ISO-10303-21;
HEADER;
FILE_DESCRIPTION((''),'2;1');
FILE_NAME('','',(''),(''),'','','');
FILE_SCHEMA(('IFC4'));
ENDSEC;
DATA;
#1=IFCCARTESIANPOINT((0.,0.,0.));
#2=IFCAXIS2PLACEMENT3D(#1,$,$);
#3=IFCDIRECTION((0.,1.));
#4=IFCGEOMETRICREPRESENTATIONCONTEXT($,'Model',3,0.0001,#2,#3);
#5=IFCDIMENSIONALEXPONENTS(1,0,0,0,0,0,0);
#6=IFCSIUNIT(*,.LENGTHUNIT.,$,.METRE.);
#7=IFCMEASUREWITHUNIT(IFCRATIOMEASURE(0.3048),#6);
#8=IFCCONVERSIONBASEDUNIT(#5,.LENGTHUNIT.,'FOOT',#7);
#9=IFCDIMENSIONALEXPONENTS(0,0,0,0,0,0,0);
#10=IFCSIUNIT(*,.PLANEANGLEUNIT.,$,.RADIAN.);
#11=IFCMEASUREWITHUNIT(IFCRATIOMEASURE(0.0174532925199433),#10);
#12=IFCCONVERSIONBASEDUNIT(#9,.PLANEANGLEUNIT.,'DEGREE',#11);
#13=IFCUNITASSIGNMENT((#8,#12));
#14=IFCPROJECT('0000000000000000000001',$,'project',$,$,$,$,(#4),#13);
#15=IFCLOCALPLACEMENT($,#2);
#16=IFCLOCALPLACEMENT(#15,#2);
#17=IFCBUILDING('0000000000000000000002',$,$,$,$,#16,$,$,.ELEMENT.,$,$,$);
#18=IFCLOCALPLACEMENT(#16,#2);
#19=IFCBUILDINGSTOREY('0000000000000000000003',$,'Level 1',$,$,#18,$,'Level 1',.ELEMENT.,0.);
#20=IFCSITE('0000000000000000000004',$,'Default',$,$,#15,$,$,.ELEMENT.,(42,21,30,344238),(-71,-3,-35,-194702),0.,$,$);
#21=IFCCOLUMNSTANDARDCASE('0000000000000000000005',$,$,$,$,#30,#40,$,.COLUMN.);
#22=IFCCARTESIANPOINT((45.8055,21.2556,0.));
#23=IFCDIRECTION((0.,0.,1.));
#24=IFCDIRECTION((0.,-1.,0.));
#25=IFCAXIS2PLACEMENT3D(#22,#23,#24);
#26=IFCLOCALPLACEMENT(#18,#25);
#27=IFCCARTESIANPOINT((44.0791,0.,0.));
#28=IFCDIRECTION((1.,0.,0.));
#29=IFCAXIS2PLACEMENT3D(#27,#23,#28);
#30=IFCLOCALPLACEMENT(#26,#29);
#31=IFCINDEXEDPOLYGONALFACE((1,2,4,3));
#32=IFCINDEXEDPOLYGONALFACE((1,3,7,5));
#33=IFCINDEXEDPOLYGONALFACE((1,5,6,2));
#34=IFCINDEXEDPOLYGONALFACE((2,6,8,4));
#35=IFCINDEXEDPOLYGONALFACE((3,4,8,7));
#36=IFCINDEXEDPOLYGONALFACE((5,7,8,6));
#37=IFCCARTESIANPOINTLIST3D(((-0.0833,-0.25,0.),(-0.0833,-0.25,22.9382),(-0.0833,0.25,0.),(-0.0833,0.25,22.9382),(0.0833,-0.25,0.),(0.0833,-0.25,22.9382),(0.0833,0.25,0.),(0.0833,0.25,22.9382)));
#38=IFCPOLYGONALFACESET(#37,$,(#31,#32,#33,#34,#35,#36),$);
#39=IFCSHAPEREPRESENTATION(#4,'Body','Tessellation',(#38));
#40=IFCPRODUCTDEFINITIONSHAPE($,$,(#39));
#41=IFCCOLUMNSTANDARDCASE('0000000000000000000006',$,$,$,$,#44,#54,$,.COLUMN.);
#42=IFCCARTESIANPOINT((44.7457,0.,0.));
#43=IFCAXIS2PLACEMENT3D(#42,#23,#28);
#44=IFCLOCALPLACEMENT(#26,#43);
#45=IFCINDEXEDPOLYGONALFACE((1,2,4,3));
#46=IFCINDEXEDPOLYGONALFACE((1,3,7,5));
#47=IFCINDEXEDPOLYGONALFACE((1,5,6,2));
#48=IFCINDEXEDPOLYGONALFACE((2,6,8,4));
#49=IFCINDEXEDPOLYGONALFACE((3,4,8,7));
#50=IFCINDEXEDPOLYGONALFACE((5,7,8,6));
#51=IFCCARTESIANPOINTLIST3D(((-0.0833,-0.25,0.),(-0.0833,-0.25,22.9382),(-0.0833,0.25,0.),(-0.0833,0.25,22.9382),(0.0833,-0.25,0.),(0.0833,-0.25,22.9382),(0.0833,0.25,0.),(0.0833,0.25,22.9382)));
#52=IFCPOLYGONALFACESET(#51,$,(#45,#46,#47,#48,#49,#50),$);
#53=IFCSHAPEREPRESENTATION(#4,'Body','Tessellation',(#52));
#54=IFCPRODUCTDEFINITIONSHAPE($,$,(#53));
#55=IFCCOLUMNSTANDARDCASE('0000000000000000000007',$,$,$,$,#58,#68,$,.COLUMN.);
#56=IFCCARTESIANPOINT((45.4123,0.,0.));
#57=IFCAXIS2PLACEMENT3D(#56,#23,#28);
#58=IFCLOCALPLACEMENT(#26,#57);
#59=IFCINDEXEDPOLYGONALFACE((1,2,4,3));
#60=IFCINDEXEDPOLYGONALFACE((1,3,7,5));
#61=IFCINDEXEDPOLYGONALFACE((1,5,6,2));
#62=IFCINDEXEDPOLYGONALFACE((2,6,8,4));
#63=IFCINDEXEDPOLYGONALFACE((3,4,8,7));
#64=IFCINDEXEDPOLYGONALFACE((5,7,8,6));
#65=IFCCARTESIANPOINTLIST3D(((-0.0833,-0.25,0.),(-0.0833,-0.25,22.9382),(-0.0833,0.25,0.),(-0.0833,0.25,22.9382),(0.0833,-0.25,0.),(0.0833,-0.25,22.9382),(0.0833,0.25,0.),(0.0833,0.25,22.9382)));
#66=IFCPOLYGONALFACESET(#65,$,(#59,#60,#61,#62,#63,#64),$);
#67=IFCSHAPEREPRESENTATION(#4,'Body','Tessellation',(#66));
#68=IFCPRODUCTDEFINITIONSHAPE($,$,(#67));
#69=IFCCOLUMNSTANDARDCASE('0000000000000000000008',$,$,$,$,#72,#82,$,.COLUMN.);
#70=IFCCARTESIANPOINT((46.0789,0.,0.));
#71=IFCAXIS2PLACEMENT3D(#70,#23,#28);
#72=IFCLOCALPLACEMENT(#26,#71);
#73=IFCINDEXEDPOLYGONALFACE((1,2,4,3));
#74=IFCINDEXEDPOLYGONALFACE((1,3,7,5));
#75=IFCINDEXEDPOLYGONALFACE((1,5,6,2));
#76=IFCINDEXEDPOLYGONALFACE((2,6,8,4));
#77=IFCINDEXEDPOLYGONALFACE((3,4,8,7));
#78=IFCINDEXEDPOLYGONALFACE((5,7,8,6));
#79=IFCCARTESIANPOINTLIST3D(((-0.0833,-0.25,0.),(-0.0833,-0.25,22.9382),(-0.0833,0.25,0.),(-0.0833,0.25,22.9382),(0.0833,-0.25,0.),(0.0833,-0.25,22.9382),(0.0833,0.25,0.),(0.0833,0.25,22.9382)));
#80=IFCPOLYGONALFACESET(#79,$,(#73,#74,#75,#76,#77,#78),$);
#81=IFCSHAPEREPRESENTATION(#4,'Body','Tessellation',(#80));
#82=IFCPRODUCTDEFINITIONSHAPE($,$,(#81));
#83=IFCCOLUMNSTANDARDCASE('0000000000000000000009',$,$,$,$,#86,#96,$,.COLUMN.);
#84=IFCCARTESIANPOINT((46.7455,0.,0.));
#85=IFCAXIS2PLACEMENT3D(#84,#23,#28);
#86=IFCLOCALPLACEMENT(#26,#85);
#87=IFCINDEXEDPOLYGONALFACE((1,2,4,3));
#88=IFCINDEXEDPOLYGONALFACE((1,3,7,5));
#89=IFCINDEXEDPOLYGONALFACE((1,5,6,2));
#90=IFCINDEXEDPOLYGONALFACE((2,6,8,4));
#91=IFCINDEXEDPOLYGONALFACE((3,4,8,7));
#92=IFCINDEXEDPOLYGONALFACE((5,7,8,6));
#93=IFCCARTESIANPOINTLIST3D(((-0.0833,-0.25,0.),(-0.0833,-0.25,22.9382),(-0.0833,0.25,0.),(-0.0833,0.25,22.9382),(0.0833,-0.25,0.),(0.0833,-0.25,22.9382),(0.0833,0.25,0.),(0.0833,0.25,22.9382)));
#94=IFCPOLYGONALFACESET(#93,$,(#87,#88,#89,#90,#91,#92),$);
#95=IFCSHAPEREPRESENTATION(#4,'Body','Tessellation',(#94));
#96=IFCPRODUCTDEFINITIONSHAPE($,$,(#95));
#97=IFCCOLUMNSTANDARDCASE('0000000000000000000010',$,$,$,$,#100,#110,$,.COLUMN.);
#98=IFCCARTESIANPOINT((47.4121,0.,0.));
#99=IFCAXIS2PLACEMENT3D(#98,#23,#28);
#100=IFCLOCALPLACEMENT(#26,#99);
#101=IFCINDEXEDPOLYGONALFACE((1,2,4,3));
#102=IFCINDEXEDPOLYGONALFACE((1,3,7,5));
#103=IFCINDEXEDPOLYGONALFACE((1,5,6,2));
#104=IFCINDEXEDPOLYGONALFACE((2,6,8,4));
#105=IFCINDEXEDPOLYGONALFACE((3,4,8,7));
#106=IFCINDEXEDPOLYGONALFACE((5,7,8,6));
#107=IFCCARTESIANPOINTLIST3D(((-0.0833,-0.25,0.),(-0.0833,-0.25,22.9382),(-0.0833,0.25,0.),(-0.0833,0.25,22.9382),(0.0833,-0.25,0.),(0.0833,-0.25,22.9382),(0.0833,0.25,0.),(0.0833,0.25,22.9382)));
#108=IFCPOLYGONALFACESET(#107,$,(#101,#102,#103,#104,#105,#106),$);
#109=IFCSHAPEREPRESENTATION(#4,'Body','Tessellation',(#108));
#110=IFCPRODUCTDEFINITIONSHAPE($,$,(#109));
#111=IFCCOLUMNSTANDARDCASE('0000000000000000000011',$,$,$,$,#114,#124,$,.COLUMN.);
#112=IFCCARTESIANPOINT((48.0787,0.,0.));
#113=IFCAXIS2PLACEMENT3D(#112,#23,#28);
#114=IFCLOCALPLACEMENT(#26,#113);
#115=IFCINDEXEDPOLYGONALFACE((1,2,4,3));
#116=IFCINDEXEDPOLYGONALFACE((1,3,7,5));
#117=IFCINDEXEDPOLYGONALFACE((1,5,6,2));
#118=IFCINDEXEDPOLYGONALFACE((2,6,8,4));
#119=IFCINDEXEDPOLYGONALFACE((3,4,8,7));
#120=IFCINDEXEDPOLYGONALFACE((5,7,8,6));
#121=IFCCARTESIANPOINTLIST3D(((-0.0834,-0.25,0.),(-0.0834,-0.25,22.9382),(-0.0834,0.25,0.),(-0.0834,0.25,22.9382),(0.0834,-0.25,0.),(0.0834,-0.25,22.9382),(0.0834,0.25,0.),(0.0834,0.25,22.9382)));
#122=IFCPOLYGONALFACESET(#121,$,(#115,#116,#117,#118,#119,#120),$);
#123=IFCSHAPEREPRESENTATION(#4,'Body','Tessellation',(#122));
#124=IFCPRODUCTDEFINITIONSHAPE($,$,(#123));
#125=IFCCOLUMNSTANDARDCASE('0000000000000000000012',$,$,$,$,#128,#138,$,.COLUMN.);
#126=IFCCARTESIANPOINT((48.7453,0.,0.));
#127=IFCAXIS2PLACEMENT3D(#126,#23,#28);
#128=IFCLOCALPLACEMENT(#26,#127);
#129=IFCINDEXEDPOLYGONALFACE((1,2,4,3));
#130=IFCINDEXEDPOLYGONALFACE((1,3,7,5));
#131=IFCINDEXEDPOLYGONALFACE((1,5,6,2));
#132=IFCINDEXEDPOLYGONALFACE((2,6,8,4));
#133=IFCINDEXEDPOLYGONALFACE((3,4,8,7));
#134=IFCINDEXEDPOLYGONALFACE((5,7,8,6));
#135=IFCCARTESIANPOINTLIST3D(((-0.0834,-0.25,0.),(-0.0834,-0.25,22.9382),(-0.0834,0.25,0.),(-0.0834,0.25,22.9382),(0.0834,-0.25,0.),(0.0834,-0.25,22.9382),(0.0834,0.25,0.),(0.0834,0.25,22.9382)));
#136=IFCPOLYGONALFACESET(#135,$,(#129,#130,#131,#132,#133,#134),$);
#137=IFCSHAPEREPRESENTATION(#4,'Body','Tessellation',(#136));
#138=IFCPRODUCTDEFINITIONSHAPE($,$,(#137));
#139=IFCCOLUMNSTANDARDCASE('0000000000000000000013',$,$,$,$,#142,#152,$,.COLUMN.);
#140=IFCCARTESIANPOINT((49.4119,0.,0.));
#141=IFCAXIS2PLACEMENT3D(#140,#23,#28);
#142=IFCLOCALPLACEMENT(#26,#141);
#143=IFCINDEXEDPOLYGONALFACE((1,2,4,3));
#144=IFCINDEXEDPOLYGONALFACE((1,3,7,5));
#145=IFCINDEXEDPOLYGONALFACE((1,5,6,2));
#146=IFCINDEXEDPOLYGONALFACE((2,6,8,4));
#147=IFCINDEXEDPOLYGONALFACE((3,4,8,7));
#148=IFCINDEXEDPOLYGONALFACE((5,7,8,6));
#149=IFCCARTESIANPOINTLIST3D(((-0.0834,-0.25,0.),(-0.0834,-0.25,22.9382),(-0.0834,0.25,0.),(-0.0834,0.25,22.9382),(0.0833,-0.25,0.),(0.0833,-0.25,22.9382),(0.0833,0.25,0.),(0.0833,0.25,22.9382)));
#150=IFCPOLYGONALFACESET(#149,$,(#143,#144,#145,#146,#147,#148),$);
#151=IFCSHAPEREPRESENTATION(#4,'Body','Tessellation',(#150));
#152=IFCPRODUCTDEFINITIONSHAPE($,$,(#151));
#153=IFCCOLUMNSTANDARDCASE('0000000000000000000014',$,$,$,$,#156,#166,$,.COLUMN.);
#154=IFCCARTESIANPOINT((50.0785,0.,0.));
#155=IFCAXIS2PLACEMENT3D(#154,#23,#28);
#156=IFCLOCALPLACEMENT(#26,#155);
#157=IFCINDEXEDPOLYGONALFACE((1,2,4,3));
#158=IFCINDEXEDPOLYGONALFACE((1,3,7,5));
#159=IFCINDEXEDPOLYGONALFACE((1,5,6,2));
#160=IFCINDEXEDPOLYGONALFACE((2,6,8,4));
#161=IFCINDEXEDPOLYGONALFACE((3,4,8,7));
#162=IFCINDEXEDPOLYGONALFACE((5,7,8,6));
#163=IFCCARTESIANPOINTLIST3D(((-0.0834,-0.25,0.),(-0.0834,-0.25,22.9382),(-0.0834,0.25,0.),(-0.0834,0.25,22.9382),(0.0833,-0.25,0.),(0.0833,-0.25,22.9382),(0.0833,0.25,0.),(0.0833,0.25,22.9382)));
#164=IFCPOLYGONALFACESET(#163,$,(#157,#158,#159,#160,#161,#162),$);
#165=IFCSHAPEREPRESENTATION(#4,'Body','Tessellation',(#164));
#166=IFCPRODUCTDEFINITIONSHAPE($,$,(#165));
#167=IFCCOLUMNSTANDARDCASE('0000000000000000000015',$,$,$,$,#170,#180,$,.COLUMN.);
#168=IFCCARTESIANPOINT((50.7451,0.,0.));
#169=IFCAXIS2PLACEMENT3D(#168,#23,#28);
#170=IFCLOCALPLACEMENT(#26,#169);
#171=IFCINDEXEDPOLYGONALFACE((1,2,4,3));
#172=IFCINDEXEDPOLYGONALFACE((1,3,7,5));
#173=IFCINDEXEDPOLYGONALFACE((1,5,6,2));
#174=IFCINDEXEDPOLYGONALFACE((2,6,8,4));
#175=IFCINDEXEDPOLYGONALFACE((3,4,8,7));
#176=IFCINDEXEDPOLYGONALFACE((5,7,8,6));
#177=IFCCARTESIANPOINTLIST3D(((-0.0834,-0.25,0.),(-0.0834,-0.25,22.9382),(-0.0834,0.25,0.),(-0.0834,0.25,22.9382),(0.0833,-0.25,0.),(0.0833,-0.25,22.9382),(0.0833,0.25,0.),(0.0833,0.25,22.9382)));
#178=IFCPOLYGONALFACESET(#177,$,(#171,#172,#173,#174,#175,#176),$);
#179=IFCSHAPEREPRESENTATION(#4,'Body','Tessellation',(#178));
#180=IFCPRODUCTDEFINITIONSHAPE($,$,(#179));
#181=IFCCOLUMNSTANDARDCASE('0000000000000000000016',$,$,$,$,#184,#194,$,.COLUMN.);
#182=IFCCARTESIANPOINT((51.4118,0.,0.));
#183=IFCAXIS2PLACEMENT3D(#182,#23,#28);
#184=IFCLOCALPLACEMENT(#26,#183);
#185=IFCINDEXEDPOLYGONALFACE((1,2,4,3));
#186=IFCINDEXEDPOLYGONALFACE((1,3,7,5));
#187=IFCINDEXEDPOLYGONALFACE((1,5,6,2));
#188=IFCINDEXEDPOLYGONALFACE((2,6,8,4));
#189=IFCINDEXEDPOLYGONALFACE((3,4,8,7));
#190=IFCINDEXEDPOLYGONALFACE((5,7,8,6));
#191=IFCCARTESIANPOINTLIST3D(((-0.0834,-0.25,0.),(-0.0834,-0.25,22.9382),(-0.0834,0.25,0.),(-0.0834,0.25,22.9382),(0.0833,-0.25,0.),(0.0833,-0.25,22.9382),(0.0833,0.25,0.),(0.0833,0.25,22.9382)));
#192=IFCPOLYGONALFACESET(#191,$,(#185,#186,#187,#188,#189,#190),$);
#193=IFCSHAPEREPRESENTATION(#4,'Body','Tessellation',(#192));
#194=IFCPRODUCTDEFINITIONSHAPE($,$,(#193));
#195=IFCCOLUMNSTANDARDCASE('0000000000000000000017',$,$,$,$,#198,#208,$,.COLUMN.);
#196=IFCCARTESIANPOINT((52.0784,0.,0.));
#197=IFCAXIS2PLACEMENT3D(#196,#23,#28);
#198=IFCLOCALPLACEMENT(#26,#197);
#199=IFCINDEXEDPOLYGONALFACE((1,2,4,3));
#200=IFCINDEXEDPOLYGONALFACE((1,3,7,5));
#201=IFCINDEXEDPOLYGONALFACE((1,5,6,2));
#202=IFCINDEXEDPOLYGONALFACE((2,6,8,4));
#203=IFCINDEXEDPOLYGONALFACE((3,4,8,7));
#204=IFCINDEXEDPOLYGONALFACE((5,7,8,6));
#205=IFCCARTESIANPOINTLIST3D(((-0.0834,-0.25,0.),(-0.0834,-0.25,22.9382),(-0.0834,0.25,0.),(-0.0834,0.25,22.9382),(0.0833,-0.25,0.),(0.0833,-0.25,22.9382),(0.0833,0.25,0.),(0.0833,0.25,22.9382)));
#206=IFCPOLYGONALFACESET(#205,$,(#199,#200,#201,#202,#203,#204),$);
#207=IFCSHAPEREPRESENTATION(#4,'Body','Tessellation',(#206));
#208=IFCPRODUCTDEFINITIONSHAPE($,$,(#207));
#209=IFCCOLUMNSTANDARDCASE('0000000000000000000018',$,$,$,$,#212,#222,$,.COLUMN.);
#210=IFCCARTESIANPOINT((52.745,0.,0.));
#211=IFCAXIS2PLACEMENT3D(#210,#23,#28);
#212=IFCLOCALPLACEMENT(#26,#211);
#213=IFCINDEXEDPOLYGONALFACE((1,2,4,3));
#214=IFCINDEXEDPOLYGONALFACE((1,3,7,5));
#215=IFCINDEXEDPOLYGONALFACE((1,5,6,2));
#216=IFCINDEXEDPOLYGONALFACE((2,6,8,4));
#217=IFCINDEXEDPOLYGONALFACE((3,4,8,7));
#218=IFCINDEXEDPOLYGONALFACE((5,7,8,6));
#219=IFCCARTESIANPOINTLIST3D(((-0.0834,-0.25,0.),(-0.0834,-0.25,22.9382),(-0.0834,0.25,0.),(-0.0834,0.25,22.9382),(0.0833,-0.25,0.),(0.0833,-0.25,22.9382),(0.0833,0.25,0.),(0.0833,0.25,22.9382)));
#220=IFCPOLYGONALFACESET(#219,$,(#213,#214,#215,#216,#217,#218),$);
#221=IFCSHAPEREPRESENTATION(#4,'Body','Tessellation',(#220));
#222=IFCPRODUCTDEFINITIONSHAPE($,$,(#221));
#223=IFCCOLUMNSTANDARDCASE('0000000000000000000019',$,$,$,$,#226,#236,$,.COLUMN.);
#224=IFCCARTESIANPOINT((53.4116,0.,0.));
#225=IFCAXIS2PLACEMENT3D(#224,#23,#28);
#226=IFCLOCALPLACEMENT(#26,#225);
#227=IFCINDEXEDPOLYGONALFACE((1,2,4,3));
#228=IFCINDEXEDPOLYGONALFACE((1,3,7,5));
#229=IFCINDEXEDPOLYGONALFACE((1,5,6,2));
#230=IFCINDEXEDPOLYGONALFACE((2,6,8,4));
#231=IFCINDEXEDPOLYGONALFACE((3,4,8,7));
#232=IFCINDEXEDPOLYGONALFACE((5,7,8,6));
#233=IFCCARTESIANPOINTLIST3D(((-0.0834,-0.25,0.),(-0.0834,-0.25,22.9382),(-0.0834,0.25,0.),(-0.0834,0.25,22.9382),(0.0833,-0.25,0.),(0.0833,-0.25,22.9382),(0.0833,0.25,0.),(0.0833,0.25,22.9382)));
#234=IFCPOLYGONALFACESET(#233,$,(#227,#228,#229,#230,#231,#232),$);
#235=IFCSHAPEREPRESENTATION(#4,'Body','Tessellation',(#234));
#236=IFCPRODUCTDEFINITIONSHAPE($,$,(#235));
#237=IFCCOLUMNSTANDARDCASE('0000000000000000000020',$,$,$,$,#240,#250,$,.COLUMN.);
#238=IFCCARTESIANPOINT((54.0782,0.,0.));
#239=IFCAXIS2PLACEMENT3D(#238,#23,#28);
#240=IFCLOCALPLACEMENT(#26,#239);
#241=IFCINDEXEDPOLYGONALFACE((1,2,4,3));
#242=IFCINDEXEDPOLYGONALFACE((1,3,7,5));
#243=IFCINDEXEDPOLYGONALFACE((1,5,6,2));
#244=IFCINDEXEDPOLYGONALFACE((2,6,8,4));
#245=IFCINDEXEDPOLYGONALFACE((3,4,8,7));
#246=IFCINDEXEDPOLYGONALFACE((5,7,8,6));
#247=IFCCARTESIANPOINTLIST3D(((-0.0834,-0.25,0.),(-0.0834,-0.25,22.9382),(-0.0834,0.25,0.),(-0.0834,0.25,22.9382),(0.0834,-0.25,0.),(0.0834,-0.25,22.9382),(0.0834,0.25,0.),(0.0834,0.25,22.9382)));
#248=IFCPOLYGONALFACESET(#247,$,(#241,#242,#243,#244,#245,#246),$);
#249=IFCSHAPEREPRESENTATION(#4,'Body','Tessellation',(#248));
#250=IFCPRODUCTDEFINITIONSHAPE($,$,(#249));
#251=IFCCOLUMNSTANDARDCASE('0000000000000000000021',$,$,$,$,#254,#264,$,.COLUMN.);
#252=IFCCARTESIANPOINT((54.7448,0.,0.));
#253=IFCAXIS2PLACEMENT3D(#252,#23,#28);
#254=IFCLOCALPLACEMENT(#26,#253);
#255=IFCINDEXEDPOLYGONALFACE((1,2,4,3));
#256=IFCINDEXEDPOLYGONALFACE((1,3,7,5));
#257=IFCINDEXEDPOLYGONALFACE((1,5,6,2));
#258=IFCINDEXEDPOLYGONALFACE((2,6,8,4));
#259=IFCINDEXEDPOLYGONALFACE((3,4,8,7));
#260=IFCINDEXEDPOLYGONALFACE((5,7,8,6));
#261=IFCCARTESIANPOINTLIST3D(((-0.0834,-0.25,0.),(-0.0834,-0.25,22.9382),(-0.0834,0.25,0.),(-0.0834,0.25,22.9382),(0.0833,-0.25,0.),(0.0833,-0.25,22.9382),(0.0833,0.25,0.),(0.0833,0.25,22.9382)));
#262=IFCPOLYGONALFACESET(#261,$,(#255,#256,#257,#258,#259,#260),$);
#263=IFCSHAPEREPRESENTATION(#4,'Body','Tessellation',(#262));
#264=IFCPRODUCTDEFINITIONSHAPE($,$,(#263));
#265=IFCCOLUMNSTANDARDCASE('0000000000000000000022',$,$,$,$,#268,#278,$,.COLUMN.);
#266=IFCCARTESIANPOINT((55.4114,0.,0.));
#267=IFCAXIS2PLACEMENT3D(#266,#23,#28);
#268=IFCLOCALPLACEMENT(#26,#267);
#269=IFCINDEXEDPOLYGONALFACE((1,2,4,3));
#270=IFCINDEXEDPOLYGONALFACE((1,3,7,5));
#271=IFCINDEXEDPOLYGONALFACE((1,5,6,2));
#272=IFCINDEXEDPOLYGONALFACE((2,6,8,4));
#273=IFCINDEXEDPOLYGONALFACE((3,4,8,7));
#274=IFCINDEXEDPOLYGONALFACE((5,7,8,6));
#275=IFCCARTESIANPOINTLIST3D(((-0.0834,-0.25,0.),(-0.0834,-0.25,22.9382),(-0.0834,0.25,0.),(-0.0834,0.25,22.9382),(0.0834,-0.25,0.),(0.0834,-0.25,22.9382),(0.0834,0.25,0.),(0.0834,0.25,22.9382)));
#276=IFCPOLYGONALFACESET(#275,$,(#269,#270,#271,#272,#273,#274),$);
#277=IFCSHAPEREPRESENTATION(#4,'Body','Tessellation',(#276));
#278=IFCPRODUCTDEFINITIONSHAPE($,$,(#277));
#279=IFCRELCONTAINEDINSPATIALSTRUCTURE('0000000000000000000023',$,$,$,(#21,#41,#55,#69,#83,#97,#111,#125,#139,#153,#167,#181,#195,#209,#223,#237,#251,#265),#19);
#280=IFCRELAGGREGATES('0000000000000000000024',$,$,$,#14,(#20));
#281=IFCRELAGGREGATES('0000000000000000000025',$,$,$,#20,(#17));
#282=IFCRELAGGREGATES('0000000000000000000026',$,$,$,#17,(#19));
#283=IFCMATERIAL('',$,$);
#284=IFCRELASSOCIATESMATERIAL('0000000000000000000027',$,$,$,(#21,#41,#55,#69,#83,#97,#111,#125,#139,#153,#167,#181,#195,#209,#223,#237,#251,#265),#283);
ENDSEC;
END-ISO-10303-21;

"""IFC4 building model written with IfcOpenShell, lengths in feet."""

from ifc_helpers import new_model, entity, si_unit, converted_unit, direction, frame, origin, place, context, project, spatial, rectangle, extrude, material, element, save


model = new_model("IFC4")

# Units and contexts
model_context = context("Model", 3, precision=0.0001, world=origin(), true_north=direction((0.0, 1.0)))
ifc_project = project(units=[converted_unit("LENGTHUNIT", "FOOT", entity("IfcRatioMeasure", 0.3048), si_unit("LENGTHUNIT", "METRE"), dimensions=[1, 0, 0, 0, 0, 0, 0]), converted_unit("PLANEANGLEUNIT", "DEGREE", entity("IfcRatioMeasure", 0.0174532925199433), si_unit("PLANEANGLEUNIT", "RADIAN"), dimensions=[0, 0, 0, 0, 0, 0, 0])], contexts=[model_context])

# Site, building, storey
site_placement = place(None, origin())
site = spatial("IfcSite", under=ifc_project, at=site_placement, Name="Default", CompositionType="ELEMENT", RefLatitude=(42, 21, 30, 344238), RefLongitude=(-71, -3, -35, -194702), RefElevation=0.0)
building_placement = place(site_placement, origin())
building = spatial("IfcBuilding", under=site, at=building_placement, CompositionType="ELEMENT")
storey_placement = place(building_placement, origin())
storey = spatial("IfcBuildingStorey", under=building, at=storey_placement, Name="Level 1", LongName="Level 1", CompositionType="ELEMENT", Elevation=0.0)

# Columns
ifc_material_1 = material(Name="")
placement = place(storey_placement, frame((45.8055, 21.2556, 0.0), z_axis=(0.0, 0.0, 1.0), x_axis=(0.0, -1.0, 0.0)))
for number, where, z_axis, x_axis in (
    (1, (44.0791, 0.0, 0.0), (0.0, 0.0, 1.0), (1.0, 0.0, 0.0)),
    (2, (44.7457, 0.0, 0.0), (0.0, 0.0, 1.0), (1.0, 0.0, 0.0)),
    (3, (45.4123, 0.0, 0.0), (0.0, 0.0, 1.0), (1.0, 0.0, 0.0)),
    (4, (46.0789, 0.0, 0.0), (0.0, 0.0, 1.0), (1.0, 0.0, 0.0)),
    (5, (46.7455, 0.0, 0.0), (0.0, 0.0, 1.0), (1.0, 0.0, 0.0)),
    (6, (47.4121, 0.0, 0.0), (0.0, 0.0, 1.0), (1.0, 0.0, 0.0)),
    (7, (48.0787, 0.0, 0.0), (0.0, 0.0, 1.0), (1.0, 0.0, 0.0)),
    (8, (48.7453, 0.0, 0.0), (0.0, 0.0, 1.0), (1.0, 0.0, 0.0)),
    (9, (49.4119, 0.0, 0.0), (0.0, 0.0, 1.0), (1.0, 0.0, 0.0)),
    (10, (50.0785, 0.0, 0.0), (0.0, 0.0, 1.0), (1.0, 0.0, 0.0)),
    (11, (50.7451, 0.0, 0.0), (0.0, 0.0, 1.0), (1.0, 0.0, 0.0)),
    (12, (51.4118, 0.0, 0.0), (0.0, 0.0, 1.0), (1.0, 0.0, 0.0)),
    (13, (52.0784, 0.0, 0.0), (0.0, 0.0, 1.0), (1.0, 0.0, 0.0)),
    (14, (52.745, 0.0, 0.0), (0.0, 0.0, 1.0), (1.0, 0.0, 0.0)),
    (15, (53.4116, 0.0, 0.0), (0.0, 0.0, 1.0), (1.0, 0.0, 0.0)),
    (16, (54.0782, 0.0, 0.0), (0.0, 0.0, 1.0), (1.0, 0.0, 0.0)),
    (17, (54.7448, 0.0, 0.0), (0.0, 0.0, 1.0), (1.0, 0.0, 0.0)),
    (18, (55.4114, 0.0, 0.0), (0.0, 0.0, 1.0), (1.0, 0.0, 0.0)),
):
    element("IfcColumnStandardCase", number, at=place(placement, frame(where, z_axis=z_axis, x_axis=x_axis)), inside=storey, material=ifc_material_1, PredefinedType="COLUMN", context=model_context, shape_type="SweptSolid", body=[
        extrude(rectangle(XDim=0.1667, YDim=0.5), origin(), (0.0, 0.0, 1.0), 22.9382),
    ])

save(model, "model.ifc")
